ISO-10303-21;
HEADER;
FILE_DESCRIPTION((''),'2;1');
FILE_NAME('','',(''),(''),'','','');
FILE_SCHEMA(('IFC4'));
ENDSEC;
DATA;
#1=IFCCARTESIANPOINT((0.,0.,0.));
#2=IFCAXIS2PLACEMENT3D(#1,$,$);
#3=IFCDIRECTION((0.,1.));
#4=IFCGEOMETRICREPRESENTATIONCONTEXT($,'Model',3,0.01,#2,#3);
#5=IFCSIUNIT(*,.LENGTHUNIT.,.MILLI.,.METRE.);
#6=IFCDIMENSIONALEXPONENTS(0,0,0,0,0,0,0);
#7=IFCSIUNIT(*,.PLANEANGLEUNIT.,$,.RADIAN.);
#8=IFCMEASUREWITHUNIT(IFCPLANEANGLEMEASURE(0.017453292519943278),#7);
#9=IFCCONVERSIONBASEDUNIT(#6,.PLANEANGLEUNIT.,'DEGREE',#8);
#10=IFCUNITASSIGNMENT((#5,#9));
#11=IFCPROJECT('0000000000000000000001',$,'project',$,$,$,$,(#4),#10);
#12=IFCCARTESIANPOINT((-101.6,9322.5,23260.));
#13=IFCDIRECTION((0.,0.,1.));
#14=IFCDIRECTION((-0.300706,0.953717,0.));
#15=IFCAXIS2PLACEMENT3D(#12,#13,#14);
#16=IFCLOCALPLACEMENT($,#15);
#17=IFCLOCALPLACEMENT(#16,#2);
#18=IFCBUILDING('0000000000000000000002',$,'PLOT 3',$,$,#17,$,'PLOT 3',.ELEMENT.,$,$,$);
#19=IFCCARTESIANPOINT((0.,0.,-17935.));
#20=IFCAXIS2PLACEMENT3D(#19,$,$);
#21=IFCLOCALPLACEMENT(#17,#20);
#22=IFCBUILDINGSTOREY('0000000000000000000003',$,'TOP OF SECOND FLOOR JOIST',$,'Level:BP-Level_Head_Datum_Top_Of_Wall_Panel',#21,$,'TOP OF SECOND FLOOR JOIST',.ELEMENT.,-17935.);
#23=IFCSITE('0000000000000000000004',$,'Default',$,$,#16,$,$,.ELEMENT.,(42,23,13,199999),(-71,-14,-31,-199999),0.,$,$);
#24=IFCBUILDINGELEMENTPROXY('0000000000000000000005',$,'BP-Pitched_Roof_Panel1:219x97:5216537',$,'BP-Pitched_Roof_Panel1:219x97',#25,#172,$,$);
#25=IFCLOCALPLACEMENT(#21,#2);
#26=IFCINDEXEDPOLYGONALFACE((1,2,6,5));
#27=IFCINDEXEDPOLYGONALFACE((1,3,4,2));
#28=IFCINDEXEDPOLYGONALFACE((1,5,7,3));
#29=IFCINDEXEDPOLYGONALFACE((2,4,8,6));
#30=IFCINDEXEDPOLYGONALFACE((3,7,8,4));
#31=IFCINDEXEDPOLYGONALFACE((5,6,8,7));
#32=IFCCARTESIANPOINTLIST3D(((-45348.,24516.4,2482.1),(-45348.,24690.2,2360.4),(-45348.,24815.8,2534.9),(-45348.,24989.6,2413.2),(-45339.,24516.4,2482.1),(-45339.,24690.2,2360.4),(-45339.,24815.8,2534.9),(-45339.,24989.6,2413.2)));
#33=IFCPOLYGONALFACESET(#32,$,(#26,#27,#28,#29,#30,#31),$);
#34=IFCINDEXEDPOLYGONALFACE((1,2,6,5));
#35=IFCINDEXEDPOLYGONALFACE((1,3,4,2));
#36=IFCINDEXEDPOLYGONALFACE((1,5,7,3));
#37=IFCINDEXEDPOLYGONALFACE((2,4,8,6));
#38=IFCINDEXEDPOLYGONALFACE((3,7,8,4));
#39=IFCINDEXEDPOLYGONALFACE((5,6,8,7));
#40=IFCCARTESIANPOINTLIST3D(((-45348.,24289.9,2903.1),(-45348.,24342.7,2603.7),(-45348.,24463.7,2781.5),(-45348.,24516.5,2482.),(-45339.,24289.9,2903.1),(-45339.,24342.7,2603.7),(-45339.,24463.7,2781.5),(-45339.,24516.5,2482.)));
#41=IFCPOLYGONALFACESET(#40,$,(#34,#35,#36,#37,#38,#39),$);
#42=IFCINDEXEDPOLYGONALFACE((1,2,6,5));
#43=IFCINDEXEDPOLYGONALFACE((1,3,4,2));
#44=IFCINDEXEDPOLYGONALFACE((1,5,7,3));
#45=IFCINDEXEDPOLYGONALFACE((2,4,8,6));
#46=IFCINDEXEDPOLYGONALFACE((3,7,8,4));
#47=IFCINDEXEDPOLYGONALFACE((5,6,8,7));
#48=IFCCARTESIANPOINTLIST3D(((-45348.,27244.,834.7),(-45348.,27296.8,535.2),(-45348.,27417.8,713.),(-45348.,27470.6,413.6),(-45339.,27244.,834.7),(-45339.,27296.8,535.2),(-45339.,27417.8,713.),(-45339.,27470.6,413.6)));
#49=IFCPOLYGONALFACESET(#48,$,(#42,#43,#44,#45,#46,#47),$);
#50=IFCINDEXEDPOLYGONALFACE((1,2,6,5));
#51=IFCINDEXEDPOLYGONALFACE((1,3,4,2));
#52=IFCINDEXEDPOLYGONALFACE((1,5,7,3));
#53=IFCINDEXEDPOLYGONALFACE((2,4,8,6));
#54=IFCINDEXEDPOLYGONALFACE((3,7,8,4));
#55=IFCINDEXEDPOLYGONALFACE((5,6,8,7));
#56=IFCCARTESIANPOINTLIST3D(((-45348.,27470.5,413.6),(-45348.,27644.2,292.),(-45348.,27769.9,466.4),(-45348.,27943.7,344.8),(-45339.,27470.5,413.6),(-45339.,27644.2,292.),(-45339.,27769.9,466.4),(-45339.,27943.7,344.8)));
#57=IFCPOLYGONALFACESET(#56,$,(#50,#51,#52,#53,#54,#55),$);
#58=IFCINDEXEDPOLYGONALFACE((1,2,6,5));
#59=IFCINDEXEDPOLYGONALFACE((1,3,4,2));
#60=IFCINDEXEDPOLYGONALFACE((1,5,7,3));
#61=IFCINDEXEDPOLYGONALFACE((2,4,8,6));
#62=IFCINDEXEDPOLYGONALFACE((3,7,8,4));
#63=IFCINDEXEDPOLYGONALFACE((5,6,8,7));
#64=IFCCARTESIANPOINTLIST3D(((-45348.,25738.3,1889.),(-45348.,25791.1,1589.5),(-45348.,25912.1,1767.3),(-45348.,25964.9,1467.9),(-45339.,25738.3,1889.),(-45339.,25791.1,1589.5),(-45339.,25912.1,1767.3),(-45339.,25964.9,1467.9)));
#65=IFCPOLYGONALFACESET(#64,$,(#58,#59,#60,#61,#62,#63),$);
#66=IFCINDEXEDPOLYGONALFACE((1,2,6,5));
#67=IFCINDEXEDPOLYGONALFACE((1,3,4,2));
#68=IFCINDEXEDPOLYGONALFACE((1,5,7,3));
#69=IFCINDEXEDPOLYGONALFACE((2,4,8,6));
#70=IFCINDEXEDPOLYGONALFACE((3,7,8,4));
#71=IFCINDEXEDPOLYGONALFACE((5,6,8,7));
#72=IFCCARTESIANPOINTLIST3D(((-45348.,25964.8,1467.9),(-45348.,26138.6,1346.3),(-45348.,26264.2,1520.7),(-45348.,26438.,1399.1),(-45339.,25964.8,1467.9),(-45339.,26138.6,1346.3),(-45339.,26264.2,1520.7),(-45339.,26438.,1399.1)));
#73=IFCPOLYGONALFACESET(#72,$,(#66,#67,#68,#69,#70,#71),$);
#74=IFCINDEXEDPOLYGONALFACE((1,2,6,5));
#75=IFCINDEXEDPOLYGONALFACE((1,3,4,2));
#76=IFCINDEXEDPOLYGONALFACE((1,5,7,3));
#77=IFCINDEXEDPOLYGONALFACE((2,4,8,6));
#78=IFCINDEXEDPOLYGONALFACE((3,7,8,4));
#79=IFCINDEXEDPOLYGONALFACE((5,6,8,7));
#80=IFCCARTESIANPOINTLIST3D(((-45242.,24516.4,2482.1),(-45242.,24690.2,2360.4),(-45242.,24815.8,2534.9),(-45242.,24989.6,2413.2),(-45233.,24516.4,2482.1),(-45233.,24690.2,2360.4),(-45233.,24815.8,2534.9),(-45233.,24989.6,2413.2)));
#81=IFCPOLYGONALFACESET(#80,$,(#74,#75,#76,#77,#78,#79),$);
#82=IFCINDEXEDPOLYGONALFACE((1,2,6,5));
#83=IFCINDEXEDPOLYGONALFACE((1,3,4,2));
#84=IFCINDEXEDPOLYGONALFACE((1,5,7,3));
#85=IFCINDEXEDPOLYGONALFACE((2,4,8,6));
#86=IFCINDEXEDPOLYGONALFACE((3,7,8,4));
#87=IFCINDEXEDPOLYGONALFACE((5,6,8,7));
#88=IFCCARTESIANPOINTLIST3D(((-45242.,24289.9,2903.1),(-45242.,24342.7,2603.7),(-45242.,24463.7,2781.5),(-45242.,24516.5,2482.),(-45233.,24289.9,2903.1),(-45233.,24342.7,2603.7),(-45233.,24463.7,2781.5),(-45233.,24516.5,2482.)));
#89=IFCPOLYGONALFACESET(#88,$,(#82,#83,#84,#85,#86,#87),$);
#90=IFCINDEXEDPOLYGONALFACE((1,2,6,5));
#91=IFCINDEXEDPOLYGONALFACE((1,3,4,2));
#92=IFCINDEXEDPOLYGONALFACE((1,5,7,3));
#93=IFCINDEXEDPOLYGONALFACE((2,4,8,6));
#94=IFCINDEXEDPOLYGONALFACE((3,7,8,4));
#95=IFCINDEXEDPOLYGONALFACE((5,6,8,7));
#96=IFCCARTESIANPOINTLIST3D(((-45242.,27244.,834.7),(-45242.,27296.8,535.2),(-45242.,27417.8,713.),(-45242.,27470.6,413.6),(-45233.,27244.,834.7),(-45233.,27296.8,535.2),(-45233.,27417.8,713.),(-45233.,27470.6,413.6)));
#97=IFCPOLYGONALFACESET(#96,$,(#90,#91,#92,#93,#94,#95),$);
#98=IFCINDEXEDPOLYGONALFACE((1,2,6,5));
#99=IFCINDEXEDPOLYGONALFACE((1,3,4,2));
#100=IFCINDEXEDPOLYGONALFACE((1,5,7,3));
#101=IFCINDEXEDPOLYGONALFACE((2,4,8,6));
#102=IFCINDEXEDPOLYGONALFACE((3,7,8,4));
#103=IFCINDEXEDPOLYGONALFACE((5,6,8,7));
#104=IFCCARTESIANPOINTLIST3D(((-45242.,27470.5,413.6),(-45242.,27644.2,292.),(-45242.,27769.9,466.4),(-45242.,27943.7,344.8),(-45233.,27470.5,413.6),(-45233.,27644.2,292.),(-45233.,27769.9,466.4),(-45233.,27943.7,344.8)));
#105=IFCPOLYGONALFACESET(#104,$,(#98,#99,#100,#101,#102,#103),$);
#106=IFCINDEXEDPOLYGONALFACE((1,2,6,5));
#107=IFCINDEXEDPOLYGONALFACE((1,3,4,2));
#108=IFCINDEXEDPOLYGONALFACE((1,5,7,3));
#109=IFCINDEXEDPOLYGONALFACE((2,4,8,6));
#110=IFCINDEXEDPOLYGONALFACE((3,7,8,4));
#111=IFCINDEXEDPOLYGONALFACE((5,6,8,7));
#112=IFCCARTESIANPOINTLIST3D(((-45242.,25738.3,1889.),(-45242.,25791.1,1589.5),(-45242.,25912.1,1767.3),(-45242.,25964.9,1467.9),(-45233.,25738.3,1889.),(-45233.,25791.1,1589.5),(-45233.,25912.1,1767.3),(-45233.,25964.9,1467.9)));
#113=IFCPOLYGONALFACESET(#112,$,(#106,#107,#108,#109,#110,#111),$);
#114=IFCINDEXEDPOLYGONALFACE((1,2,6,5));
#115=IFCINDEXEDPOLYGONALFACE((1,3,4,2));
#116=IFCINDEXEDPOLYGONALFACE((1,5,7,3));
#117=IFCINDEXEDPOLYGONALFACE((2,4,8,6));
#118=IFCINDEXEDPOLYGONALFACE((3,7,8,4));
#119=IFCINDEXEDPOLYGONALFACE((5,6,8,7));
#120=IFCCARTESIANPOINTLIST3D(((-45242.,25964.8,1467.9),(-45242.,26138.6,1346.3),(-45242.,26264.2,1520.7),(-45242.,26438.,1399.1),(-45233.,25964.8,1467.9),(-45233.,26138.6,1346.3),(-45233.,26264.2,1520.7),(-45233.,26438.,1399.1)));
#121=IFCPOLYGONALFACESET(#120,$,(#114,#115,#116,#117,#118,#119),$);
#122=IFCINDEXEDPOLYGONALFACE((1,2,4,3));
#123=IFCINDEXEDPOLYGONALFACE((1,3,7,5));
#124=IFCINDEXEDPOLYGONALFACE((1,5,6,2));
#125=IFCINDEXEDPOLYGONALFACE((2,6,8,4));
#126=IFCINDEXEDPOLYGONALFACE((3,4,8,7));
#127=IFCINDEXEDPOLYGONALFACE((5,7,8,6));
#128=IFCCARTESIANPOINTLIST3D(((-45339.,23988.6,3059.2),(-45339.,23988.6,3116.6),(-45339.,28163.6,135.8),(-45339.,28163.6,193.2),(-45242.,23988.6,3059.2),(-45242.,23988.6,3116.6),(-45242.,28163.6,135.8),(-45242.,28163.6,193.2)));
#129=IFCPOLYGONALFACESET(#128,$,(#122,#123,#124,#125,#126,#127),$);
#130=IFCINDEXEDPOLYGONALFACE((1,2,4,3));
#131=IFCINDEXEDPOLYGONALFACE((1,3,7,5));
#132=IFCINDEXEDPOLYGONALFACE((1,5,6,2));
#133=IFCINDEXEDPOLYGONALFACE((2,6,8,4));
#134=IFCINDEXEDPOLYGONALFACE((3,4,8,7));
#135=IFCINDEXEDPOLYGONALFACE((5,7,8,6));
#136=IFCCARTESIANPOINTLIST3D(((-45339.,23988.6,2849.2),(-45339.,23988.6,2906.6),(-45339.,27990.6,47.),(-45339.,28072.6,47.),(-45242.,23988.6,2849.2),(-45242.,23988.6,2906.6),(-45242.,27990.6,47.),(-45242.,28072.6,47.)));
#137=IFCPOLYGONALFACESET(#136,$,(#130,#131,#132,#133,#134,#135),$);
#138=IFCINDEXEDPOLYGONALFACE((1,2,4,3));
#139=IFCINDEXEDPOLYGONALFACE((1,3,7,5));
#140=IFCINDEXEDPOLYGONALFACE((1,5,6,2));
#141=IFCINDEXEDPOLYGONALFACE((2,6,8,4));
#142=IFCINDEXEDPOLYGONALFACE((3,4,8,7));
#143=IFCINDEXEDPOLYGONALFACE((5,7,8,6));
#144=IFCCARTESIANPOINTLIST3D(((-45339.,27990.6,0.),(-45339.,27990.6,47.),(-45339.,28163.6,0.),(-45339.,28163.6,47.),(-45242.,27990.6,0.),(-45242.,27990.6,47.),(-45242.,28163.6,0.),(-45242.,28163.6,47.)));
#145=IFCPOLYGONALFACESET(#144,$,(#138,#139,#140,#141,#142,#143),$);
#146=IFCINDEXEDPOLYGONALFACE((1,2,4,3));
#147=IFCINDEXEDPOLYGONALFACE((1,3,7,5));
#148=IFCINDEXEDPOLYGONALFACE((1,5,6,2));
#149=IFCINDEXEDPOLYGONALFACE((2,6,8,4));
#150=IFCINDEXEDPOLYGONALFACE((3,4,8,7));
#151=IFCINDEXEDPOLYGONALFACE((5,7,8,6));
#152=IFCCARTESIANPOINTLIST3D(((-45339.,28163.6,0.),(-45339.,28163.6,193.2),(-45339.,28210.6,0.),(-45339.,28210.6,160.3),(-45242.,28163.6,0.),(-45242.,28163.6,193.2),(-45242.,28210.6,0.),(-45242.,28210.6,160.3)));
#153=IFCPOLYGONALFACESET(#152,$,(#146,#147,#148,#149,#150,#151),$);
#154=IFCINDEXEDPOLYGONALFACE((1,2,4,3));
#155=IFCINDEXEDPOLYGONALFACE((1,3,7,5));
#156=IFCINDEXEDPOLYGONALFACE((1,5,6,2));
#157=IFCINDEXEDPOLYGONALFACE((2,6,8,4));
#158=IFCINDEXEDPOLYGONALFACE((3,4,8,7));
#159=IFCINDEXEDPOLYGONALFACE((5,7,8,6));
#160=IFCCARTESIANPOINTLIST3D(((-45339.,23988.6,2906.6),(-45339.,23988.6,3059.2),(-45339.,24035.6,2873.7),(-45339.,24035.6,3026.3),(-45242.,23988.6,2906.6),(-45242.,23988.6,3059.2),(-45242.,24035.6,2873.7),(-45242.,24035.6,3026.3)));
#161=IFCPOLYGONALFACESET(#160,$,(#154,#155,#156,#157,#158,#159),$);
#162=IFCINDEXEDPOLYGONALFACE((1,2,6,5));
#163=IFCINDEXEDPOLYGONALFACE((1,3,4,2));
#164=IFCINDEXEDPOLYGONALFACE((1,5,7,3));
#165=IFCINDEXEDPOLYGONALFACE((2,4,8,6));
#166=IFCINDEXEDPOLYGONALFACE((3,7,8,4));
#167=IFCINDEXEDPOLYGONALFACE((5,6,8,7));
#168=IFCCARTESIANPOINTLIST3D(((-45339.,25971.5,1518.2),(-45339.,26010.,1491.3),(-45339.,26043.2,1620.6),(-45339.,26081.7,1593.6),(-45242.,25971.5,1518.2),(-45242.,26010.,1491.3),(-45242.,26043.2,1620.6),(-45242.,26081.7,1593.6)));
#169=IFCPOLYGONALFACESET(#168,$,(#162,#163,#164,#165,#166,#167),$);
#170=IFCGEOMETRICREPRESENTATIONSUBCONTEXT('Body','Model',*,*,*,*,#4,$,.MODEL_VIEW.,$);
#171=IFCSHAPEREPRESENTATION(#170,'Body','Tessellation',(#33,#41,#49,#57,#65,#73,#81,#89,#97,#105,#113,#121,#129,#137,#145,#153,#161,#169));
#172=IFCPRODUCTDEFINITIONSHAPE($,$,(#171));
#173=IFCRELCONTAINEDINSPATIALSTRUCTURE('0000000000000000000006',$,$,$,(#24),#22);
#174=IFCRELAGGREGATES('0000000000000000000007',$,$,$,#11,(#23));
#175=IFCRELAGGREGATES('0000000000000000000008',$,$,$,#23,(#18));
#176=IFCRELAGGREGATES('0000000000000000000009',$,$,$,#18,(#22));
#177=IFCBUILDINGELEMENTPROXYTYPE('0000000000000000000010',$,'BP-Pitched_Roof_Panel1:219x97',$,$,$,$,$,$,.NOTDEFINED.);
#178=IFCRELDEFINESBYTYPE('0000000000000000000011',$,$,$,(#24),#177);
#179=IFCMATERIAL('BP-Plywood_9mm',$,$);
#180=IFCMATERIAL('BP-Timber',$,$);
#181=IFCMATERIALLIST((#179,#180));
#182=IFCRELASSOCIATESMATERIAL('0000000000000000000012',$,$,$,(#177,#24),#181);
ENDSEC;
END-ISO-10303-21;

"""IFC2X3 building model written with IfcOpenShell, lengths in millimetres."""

from ifc_helpers import new_model, entity, si_unit, converted_unit, direction, frame, frame_2d, origin, origin_2d_with_axis, place, context, subcontext, project, spatial, polyline, rectangle, outline, extrude, source, transform, mapped, material, material_list, type_object, type_shapes, element, save


model = new_model("IFC2X3")

# Units and contexts
model_context = context("Model", 3, precision=0.01, world=origin(), true_north=direction((0.0, 1.0)))
body_context = subcontext(model_context, "Body", "Model", "MODEL_VIEW")
ifc_project = project(units=[si_unit("LENGTHUNIT", "METRE", prefix="MILLI"), converted_unit("PLANEANGLEUNIT", "DEGREE", entity("IfcPlaneAngleMeasure", 0.017453292519943278), si_unit("PLANEANGLEUNIT", "RADIAN"), dimensions=[0, 0, 0, 0, 0, 0, 0])], contexts=[model_context])

# Site, building, storey
site_placement = place(None, frame((-101.6, 9322.5, 23260.0), z_axis=(0.0, 0.0, 1.0), x_axis=(-0.300706, 0.953717, 0.0)))
site = spatial("IfcSite", under=ifc_project, at=site_placement, Name="Default", CompositionType="ELEMENT", RefLatitude=(42, 23, 13, 199999), RefLongitude=(-71, -14, -31, -199999), RefElevation=0.0)
building_placement = place(site_placement, origin())
building = spatial("IfcBuilding", under=site, at=building_placement, Name="PLOT 3", LongName="PLOT 3", CompositionType="ELEMENT")
storey_placement = place(building_placement, frame((0.0, 0.0, -17935.0)))
storey = spatial("IfcBuildingStorey", under=building, at=storey_placement, Name="TOP OF SECOND FLOOR JOIST", ObjectType="Level:BP-Level_Head_Datum_Top_Of_Wall_Panel", LongName="TOP OF SECOND FLOOR JOIST", CompositionType="ELEMENT", Elevation=-17935.0)

# Building element proxy
ifc_material_1 = material(Name="BP-Timber")
ifc_material_2 = material(Name="BP-Plywood_9mm")
ifc_material_list = material_list([ifc_material_2, ifc_material_1])
building_element_proxy_type_1 = type_object("IfcBuildingElementProxyType", Name="BP-Pitched_Roof_Panel1:219x97", PredefinedType="NOTDEFINED", material=ifc_material_list)
shared_shape_1 = source(origin(), body_context, "Body", "SweptSolid", [
    extrude(outline(polyline([(-77.0, -75.0), (227.0, -75.0), (77.0, 75.0), (-227.0, 75.0), (-77.0, -75.0)])), frame((35.3, -3956.0, 2447.7), z_axis=(0.0, 1.0, 0.0), x_axis=(-0.984808, 0.0, 0.173648)), (0.0, 0.0, 1.0), 9.0),
    extrude(outline(polyline([(1.4, -107.5), (213.6, -107.5), (-1.4, 107.5), (-213.6, 107.5), (1.4, -107.5)])), frame((385.1, -3956.0, 2692.6), z_axis=(0.0, 1.0, 0.0), x_axis=(-0.819152, 0.0, -0.573576)), (0.0, 0.0, 1.0), 9.0),
    extrude(outline(polyline([(1.4, -107.5), (213.6, -107.5), (-1.4, 107.5), (-213.6, 107.5), (1.4, -107.5)])), frame((-2569.0, -3956.0, 624.1), z_axis=(0.0, 1.0, 0.0), x_axis=(-0.819152, 0.0, -0.573576)), (0.0, 0.0, 1.0), 9.0),
    extrude(outline(polyline([(-77.0, -75.0), (227.0, -75.0), (77.0, 75.0), (-227.0, 75.0), (-77.0, -75.0)])), frame((-2918.8, -3956.0, 379.2), z_axis=(0.0, 1.0, 0.0), x_axis=(-0.984808, 0.0, 0.173648)), (0.0, 0.0, 1.0), 9.0),
    extrude(outline(polyline([(1.4, -107.5), (213.6, -107.5), (-1.4, 107.5), (-213.6, 107.5), (1.4, -107.5)])), frame((-1063.3, -3956.0, 1678.4), z_axis=(0.0, 1.0, 0.0), x_axis=(-0.819152, 0.0, -0.573576)), (0.0, 0.0, 1.0), 9.0),
    extrude(outline(polyline([(-77.0, -75.0), (227.0, -75.0), (77.0, 75.0), (-227.0, 75.0), (-77.0, -75.0)])), frame((-1413.1, -3956.0, 1433.5), z_axis=(0.0, 1.0, 0.0), x_axis=(-0.984808, 0.0, 0.173648)), (0.0, 0.0, 1.0), 9.0),
    extrude(outline(polyline([(-77.0, -75.0), (227.0, -75.0), (77.0, 75.0), (-227.0, 75.0), (-77.0, -75.0)])), frame((35.3, -3850.0, 2447.7), z_axis=(0.0, 1.0, 0.0), x_axis=(-0.984808, 0.0, 0.173648)), (0.0, 0.0, 1.0), 9.0),
    extrude(outline(polyline([(1.4, -107.5), (213.6, -107.5), (-1.4, 107.5), (-213.6, 107.5), (1.4, -107.5)])), frame((385.1, -3850.0, 2692.6), z_axis=(0.0, 1.0, 0.0), x_axis=(-0.819152, 0.0, -0.573576)), (0.0, 0.0, 1.0), 9.0),
    extrude(outline(polyline([(1.4, -107.5), (213.6, -107.5), (-1.4, 107.5), (-213.6, 107.5), (1.4, -107.5)])), frame((-2569.0, -3850.0, 624.1), z_axis=(0.0, 1.0, 0.0), x_axis=(-0.819152, 0.0, -0.573576)), (0.0, 0.0, 1.0), 9.0),
    extrude(outline(polyline([(-77.0, -75.0), (227.0, -75.0), (77.0, 75.0), (-227.0, 75.0), (-77.0, -75.0)])), frame((-2918.8, -3850.0, 379.2), z_axis=(0.0, 1.0, 0.0), x_axis=(-0.984808, 0.0, 0.173648)), (0.0, 0.0, 1.0), 9.0),
    extrude(outline(polyline([(1.4, -107.5), (213.6, -107.5), (-1.4, 107.5), (-213.6, 107.5), (1.4, -107.5)])), frame((-1063.3, -3850.0, 1678.4), z_axis=(0.0, 1.0, 0.0), x_axis=(-0.819152, 0.0, -0.573576)), (0.0, 0.0, 1.0), 9.0),
    extrude(outline(polyline([(-77.0, -75.0), (227.0, -75.0), (77.0, 75.0), (-227.0, 75.0), (-77.0, -75.0)])), frame((-1413.1, -3850.0, 1433.5), z_axis=(0.0, 1.0, 0.0), x_axis=(-0.984808, 0.0, 0.173648)), (0.0, 0.0, 1.0), 9.0),
    extrude(outline(polyline([(-1490.4, -2087.5), (-1433.0, -2087.5), (1490.4, 2087.5), (1433.0, 2087.5), (-1490.4, -2087.5)])), frame((-1287.8, -3947.0, 1626.2), z_axis=(0.0, 1.0, 0.0), x_axis=(0.0, 0.0, -1.0)), (0.0, 0.0, 1.0), 97.0),
    extrude(outline(polyline([(-1444.1, -2021.5), (-1386.8, -2021.5), (1415.5, 1980.5), (1415.5, 2062.5), (-1444.1, -2021.5)])), frame((-1221.8, -3947.0, 1462.5), z_axis=(0.0, 1.0, 0.0), x_axis=(0.0, 0.0, -1.0)), (0.0, 0.0, 1.0), 97.0),
    extrude(rectangle(XDim=173.0, YDim=97.0, at=origin_2d_with_axis()), frame((-3288.8, -3898.5, 0.0), z_axis=(0.0, 0.0, 1.0), x_axis=(-1.0, 0.0, 0.0)), (0.0, 0.0, 1.0), 47.0),
    extrude(outline(polyline([(22.0, -72.4), (79.4, -72.4), (-31.4, 85.9), (-69.9, 58.9), (22.0, -72.4)])), frame((-3398.8, -3947.0, 88.4), z_axis=(0.0, 1.0, 0.0), x_axis=(0.819152, 0.0, 0.573576)), (0.0, 0.0, 1.0), 97.0),
    extrude(outline(polyline([(15.1, -62.5), (72.5, -62.5), (-15.1, 62.5), (-72.5, 62.5), (15.1, -62.5)])), frame((776.2, -3947.0, 2966.5), z_axis=(0.0, 1.0, 0.0), x_axis=(0.819152, 0.0, 0.573576)), (0.0, 0.0, 1.0), 97.0),
    extrude(rectangle(XDim=47.0, YDim=97.0, at=frame_2d((0.0, 0.0), x_axis=(1.0, 0.0))), frame((-1202.4, -3898.5, 1504.7), z_axis=(-0.573576, 0.0, 0.819152), x_axis=(-0.819152, 0.0, -0.573576)), (0.0, 0.0, 1.0), 125.0),
])
type_shapes(building_element_proxy_type_1, [shared_shape_1])
for number, where, z_axis, x_axis, name in (
    (1, (-41392.0, 24788.3, 0.0), (0.0, 0.0, 1.0), (0.0, -1.0, 0.0), "BP-Pitched_Roof_Panel1:219x97:5216537"),
):
    element("IfcBuildingElementProxy", number, at=place(storey_placement, frame(where, z_axis=z_axis, x_axis=x_axis)), inside=storey, type_object=building_element_proxy_type_1, material=ifc_material_list, Name=name, ObjectType="BP-Pitched_Roof_Panel1:219x97", context=body_context, shape_type="MappedRepresentation", body=[
        mapped(shared_shape_1, transform((0.0, 0.0, 0.0), scale=1.0)),
    ])

save(model, "model.ifc")
